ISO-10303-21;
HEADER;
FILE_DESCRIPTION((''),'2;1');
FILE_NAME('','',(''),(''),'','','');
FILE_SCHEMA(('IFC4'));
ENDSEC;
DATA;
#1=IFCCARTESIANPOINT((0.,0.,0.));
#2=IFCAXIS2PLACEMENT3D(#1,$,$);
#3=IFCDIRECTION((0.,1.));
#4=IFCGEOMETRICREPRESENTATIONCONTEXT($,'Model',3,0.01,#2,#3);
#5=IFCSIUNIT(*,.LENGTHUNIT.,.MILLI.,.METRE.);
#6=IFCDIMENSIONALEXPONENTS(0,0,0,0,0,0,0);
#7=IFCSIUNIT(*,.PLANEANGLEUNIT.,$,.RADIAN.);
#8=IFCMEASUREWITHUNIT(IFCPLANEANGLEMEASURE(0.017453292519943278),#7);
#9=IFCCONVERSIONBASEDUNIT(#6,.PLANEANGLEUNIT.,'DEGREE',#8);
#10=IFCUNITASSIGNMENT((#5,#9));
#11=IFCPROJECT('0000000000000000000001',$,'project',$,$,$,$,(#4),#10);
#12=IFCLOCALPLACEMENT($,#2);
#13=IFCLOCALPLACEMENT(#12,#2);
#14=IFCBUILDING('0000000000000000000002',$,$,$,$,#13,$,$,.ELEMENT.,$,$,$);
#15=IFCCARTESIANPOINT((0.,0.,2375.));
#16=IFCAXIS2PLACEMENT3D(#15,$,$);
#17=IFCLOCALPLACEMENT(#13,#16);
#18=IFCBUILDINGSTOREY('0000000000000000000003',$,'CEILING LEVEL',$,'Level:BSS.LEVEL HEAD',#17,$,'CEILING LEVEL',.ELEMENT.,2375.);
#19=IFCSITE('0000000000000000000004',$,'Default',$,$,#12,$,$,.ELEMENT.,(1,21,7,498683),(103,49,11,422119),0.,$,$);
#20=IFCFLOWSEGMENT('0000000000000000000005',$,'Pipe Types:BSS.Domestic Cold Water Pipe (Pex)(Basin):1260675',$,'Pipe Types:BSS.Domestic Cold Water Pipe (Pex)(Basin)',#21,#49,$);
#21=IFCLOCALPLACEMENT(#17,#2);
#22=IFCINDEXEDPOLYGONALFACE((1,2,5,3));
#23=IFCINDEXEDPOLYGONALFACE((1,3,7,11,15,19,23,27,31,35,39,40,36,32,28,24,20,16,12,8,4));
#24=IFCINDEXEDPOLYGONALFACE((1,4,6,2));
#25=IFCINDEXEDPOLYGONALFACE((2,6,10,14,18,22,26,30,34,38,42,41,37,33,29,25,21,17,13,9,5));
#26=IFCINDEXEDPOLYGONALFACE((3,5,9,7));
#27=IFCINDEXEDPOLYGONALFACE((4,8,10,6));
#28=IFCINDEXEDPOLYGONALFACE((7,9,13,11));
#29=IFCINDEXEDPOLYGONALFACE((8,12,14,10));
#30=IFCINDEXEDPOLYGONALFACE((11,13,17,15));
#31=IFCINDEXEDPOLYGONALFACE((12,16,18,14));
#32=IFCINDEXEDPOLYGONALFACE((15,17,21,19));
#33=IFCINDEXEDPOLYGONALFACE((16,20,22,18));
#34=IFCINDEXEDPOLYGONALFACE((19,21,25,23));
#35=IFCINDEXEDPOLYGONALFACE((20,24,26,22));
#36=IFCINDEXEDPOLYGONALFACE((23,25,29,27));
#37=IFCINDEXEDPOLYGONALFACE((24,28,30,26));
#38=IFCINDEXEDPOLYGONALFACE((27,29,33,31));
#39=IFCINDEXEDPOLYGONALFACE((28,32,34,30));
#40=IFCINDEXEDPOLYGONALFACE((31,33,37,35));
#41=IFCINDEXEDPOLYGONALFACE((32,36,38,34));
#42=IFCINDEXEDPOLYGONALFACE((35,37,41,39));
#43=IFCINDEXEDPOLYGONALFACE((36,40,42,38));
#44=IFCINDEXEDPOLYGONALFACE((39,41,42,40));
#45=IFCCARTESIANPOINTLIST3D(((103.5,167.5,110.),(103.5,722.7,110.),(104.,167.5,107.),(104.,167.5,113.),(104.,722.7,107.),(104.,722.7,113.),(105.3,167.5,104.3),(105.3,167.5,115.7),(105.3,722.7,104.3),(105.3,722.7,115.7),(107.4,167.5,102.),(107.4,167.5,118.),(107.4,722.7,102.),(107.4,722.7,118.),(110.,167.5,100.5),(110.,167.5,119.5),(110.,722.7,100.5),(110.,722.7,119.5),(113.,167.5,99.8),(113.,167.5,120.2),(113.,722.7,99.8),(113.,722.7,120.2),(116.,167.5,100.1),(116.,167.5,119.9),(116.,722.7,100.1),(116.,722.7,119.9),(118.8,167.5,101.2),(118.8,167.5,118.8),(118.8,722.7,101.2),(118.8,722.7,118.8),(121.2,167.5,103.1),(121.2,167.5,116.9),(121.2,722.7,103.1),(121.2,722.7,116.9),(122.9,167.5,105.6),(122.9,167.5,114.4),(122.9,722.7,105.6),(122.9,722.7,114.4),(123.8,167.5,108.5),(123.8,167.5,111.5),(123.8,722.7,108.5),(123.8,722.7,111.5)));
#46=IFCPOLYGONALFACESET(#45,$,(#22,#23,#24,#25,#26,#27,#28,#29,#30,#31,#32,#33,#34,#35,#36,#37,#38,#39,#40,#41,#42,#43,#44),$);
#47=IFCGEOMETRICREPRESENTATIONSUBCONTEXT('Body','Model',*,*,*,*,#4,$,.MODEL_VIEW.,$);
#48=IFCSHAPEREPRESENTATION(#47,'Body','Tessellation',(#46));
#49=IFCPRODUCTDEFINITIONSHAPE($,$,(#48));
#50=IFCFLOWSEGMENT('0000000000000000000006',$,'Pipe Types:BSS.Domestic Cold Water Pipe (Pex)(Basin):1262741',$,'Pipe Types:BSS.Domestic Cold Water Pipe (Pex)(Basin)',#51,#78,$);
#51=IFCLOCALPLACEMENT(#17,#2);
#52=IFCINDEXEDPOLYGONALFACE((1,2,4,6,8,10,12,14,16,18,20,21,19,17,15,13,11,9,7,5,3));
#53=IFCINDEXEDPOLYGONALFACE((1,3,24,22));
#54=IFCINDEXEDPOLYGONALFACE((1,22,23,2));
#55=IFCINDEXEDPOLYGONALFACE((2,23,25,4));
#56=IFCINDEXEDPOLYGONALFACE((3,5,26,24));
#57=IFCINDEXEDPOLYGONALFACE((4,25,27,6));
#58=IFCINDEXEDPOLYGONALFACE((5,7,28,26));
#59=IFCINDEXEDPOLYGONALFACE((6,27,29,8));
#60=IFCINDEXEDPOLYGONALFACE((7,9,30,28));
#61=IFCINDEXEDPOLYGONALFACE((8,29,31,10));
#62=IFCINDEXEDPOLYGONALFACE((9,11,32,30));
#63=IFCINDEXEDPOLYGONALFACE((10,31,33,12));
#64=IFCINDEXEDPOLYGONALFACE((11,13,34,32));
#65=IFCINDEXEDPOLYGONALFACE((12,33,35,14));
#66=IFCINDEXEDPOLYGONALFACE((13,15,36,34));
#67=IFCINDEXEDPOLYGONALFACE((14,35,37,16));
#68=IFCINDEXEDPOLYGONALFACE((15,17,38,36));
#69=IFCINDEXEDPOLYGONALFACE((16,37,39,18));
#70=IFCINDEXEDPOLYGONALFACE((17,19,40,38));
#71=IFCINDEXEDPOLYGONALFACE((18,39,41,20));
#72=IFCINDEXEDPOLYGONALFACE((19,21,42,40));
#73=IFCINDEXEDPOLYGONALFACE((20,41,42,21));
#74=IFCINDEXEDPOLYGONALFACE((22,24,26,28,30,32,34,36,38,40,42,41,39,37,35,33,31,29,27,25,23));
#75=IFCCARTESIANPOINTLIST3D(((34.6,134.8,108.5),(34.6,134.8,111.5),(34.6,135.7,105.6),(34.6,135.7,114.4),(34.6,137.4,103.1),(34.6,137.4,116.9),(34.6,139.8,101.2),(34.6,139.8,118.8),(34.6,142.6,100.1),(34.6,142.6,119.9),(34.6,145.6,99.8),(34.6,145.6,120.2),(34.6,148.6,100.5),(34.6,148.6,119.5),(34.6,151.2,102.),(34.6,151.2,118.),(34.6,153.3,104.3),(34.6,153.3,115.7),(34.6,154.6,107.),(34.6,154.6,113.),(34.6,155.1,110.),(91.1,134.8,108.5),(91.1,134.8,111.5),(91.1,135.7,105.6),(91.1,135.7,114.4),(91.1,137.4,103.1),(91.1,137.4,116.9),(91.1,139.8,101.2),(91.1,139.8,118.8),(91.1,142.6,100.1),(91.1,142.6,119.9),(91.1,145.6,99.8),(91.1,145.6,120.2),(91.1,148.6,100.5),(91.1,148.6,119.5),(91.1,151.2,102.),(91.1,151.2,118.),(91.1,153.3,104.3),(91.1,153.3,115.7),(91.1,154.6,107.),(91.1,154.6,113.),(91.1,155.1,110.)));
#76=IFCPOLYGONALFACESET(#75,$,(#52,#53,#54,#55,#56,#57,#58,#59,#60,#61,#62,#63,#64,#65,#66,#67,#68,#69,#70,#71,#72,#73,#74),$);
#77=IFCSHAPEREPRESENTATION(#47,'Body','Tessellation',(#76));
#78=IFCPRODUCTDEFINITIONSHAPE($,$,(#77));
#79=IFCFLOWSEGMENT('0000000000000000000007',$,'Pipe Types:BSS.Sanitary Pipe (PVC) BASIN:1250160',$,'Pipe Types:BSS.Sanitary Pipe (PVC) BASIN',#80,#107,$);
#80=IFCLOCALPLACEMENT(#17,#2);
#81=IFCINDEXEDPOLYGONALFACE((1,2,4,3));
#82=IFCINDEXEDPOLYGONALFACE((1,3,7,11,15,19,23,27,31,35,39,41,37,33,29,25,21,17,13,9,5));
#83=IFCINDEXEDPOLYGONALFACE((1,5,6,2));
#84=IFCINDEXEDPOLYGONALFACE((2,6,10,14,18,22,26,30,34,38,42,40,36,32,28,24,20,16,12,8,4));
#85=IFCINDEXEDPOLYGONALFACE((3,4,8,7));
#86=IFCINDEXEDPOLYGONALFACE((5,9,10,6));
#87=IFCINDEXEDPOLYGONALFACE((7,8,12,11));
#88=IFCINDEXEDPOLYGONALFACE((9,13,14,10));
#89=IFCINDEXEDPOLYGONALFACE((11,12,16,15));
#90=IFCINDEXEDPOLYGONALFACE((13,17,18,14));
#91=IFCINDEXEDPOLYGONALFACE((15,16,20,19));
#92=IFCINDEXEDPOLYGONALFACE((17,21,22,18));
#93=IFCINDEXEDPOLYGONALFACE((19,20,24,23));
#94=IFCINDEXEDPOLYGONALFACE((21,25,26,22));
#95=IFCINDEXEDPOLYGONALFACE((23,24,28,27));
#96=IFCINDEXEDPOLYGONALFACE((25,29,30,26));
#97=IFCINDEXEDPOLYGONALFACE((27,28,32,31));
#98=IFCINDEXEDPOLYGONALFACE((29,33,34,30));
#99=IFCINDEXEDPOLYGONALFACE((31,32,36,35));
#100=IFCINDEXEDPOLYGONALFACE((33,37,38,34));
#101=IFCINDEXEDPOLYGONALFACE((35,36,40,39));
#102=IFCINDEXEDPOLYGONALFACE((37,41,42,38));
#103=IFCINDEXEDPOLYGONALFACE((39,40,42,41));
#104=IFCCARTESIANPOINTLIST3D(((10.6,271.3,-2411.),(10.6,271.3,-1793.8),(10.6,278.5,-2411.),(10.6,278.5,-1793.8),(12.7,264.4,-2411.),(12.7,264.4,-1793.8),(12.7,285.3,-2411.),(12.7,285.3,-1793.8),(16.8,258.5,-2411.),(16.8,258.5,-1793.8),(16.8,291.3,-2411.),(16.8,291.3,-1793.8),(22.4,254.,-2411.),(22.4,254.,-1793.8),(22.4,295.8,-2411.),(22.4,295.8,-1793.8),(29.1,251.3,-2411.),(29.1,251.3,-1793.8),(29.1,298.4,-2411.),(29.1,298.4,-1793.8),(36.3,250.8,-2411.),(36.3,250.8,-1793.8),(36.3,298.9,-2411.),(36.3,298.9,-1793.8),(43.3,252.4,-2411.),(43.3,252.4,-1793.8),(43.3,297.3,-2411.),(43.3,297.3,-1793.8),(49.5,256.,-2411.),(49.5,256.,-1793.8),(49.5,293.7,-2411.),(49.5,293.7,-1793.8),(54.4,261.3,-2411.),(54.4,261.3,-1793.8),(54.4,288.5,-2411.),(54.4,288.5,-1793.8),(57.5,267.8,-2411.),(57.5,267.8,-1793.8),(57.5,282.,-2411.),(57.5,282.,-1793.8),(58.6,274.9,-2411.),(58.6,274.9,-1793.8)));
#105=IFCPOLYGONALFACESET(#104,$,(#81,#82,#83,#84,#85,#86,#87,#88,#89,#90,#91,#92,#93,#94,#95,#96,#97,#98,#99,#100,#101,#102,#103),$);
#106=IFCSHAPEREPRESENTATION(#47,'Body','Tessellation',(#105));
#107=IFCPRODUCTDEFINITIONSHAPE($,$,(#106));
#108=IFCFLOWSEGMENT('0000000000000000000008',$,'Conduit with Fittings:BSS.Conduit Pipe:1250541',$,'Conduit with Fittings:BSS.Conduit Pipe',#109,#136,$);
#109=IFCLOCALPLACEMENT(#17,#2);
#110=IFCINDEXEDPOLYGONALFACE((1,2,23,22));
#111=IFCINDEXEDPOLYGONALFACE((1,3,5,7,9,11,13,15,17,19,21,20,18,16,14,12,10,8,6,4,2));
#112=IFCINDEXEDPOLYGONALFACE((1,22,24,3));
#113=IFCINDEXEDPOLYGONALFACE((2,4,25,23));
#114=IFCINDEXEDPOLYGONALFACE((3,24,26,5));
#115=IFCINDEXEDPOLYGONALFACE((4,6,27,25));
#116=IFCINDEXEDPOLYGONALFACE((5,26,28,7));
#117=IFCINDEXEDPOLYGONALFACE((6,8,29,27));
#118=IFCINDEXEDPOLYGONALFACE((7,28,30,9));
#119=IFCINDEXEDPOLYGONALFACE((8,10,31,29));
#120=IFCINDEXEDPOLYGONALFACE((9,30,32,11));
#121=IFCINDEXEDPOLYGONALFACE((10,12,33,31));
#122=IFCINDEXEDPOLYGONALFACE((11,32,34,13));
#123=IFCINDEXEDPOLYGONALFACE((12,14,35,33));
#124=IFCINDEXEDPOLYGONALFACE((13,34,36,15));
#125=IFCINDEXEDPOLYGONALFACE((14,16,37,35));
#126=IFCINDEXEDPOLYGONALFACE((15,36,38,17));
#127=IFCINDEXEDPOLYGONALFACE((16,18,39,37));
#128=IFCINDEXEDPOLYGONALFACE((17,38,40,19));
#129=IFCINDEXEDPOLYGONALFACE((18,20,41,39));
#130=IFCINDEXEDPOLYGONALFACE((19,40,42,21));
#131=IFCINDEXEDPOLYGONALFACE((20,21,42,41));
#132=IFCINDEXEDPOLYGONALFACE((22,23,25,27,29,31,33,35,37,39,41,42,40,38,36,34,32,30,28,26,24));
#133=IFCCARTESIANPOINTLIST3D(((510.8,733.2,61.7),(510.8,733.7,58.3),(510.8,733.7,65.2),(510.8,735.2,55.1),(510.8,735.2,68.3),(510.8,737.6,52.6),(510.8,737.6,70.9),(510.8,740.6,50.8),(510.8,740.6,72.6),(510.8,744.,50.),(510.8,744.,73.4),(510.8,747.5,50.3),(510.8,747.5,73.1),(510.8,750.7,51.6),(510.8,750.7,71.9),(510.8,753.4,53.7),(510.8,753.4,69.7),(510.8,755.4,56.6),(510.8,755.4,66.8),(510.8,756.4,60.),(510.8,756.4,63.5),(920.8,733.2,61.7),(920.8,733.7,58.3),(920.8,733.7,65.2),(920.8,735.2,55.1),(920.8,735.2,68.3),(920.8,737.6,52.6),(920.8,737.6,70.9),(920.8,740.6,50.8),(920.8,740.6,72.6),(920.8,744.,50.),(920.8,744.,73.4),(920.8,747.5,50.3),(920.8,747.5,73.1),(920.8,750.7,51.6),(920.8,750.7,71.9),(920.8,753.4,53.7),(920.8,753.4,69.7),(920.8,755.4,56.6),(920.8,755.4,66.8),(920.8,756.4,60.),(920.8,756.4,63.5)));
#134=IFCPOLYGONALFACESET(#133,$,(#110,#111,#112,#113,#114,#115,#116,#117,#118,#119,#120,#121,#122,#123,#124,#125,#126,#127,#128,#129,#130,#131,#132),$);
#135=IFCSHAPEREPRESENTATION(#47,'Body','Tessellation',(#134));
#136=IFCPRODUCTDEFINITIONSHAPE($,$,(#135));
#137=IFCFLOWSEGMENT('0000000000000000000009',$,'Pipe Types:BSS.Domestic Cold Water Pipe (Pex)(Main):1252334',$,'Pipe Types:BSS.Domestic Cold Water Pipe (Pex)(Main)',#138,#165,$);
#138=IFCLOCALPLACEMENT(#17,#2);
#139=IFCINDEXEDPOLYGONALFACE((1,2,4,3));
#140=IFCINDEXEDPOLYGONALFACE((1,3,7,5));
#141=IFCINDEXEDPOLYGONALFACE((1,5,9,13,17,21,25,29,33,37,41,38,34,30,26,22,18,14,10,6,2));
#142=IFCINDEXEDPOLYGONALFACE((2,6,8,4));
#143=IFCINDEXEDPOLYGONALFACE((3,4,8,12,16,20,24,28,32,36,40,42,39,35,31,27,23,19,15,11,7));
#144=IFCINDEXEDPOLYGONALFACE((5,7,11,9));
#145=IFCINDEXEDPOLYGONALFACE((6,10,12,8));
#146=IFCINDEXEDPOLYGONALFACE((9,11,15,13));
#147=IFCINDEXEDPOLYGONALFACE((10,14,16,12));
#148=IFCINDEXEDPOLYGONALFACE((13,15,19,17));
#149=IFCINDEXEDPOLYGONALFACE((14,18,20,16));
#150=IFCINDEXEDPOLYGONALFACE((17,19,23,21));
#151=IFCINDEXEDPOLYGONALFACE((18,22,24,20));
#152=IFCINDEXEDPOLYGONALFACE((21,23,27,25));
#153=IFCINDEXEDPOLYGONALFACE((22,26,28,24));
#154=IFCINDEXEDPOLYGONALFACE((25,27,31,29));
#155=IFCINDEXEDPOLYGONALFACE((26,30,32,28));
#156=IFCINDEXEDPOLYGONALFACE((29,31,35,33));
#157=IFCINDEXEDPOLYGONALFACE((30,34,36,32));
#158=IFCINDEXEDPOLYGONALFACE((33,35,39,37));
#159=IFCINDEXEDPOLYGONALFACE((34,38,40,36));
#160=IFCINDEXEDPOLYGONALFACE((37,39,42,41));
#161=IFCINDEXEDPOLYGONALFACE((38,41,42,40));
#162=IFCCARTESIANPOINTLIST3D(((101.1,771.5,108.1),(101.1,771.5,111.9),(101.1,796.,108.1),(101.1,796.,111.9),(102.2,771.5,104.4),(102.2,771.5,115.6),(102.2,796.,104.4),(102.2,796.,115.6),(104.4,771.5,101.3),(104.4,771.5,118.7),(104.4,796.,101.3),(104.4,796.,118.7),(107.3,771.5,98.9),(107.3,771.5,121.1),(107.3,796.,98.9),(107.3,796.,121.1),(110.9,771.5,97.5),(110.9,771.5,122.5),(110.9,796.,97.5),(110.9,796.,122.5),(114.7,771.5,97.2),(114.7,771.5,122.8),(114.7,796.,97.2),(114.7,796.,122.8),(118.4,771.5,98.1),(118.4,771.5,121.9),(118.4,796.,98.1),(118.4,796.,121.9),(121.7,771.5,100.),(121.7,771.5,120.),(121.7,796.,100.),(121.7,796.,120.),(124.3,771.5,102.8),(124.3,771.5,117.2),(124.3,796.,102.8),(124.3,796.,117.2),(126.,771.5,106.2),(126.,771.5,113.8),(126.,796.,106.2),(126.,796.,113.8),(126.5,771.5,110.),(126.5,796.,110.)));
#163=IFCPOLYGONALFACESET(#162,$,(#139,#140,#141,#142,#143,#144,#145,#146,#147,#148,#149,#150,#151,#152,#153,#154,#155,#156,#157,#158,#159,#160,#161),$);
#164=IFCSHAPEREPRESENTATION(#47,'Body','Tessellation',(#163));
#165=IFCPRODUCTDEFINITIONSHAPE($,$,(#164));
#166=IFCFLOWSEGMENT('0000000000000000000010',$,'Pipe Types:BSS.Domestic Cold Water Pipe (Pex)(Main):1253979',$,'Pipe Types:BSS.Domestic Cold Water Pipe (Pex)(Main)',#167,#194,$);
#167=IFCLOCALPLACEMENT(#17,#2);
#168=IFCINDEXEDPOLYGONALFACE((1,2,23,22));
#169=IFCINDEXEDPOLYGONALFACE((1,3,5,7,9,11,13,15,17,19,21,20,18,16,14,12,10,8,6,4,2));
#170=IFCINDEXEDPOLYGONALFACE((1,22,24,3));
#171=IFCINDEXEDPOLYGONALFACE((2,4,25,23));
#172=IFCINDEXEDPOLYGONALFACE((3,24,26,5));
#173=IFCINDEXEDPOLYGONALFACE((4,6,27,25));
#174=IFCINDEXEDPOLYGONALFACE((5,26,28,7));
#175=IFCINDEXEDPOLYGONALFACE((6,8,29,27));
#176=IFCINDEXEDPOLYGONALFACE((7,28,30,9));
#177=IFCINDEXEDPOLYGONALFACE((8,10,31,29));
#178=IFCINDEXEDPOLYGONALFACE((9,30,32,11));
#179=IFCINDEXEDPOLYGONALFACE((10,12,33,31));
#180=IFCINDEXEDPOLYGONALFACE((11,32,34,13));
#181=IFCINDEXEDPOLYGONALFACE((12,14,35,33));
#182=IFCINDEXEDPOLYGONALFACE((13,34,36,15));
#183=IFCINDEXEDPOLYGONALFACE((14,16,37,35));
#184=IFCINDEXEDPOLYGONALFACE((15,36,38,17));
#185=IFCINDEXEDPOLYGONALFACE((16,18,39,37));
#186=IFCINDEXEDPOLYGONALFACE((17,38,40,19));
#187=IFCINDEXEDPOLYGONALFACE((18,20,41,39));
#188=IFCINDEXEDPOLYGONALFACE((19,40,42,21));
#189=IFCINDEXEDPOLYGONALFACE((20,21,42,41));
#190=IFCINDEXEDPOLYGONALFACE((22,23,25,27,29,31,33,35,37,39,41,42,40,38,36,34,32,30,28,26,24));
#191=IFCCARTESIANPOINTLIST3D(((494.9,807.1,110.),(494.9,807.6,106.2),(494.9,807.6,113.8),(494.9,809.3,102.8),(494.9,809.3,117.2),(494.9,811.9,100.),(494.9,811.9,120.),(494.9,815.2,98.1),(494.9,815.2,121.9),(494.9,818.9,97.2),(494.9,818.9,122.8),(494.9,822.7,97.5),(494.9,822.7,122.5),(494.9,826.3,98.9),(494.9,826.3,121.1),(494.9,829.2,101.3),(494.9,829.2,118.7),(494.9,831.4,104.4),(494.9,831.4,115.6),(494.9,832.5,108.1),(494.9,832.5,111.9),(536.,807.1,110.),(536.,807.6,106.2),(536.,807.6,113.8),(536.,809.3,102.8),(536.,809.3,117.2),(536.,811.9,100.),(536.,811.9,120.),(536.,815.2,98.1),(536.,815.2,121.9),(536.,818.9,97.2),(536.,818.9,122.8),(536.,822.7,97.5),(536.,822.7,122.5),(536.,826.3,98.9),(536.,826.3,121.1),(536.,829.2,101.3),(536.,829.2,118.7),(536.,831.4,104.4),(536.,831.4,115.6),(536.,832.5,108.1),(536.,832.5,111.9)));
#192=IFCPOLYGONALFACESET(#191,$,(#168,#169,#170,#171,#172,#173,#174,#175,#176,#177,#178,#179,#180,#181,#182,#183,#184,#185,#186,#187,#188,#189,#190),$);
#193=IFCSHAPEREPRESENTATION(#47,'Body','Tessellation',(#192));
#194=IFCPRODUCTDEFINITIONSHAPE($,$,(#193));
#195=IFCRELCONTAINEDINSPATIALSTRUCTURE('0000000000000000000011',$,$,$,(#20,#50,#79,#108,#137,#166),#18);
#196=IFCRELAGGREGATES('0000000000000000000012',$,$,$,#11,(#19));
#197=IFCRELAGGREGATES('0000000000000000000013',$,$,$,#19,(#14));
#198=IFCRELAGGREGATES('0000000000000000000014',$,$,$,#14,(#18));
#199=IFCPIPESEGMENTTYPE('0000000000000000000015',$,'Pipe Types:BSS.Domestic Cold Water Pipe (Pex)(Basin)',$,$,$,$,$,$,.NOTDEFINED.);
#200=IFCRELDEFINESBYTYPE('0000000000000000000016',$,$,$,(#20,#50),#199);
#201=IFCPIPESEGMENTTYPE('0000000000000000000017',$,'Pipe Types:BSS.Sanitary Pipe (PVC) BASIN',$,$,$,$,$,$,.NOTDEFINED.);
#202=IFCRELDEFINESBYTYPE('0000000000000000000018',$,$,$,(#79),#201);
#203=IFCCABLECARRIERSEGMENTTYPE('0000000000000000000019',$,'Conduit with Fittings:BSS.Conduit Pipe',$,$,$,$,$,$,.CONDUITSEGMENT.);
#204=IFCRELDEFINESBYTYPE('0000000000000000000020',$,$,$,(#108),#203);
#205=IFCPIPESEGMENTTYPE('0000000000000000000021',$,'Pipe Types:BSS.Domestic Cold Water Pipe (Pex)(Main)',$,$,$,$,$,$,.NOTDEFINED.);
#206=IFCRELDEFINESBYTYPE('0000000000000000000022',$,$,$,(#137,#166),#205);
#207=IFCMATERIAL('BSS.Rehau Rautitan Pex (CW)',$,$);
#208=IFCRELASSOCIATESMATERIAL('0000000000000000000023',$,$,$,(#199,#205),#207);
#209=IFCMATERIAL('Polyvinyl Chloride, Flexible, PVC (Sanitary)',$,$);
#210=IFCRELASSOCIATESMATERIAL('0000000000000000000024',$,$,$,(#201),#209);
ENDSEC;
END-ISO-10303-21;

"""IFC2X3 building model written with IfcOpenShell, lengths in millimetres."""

from ifc_helpers import new_model, entity, si_unit, converted_unit, direction, frame, frame_2d, origin, origin_2d_with_axis, place, context, subcontext, project, spatial, circle, extrude, material, type_object, element, save


model = new_model("IFC2X3")

# Units and contexts
model_context = context("Model", 3, precision=0.01, world=origin(), true_north=direction((0.0, 1.0)))
body_context = subcontext(model_context, "Body", "Model", "MODEL_VIEW")
ifc_project = project(units=[si_unit("LENGTHUNIT", "METRE", prefix="MILLI"), converted_unit("PLANEANGLEUNIT", "DEGREE", entity("IfcPlaneAngleMeasure", 0.017453292519943278), si_unit("PLANEANGLEUNIT", "RADIAN"), dimensions=[0, 0, 0, 0, 0, 0, 0])], contexts=[model_context])

# Site, building, storey
site_placement = place(None, origin())
site = spatial("IfcSite", under=ifc_project, at=site_placement, Name="Default", CompositionType="ELEMENT", RefLatitude=(1, 21, 7, 498683), RefLongitude=(103, 49, 11, 422119), RefElevation=0.0)
building_placement = place(site_placement, origin())
building = spatial("IfcBuilding", under=site, at=building_placement, CompositionType="ELEMENT")
storey_placement = place(building_placement, frame((0.0, 0.0, 2375.0)))
storey = spatial("IfcBuildingStorey", under=building, at=storey_placement, Name="CEILING LEVEL", ObjectType="Level:BSS.LEVEL HEAD", LongName="CEILING LEVEL", CompositionType="ELEMENT", Elevation=2375.0)

# Flow segments
ifc_material_1 = material(Name="BSS.Rehau Rautitan Pex (CW)")
pipe_segment_type_1 = type_object("IfcPipeSegmentType", Name="Pipe Types:BSS.Domestic Cold Water Pipe (Pex)(Basin)", PredefinedType="NOTDEFINED", material=ifc_material_1)
flow_segment_1_placement = place(storey_placement, origin())
element("IfcFlowSegment", 1, at=flow_segment_1_placement, inside=storey, type_object=pipe_segment_type_1, Name="Pipe Types:BSS.Domestic Cold Water Pipe (Pex)(Basin):1260675", ObjectType="Pipe Types:BSS.Domestic Cold Water Pipe (Pex)(Basin)", context=body_context, shape_type="SweptSolid", body=[
    extrude(circle(Radius=10.2, at=frame_2d((0.0, 0.0), x_axis=(1.0, 0.0))), frame((113.7, 167.5, 110.0), z_axis=(0.0, 1.0, 0.0), x_axis=(-1.0, 0.0, 0.0)), (0.0, 0.0, 1.0), 555.2),
])
flow_segment_2_placement = place(storey_placement, origin())
element("IfcFlowSegment", 2, at=flow_segment_2_placement, inside=storey, type_object=pipe_segment_type_1, Name="Pipe Types:BSS.Domestic Cold Water Pipe (Pex)(Basin):1262741", ObjectType="Pipe Types:BSS.Domestic Cold Water Pipe (Pex)(Basin)", context=body_context, shape_type="SweptSolid", body=[
    extrude(circle(Radius=10.2, at=frame_2d((0.0, 0.0), x_axis=(1.0, 0.0))), frame((34.6, 144.9, 110.0), z_axis=(1.0, 0.0, 0.0), x_axis=(0.0, 1.0, 0.0)), (0.0, 0.0, 1.0), 56.5),
])
ifc_material_2 = material(Name="Polyvinyl Chloride, Flexible, PVC (Sanitary)")
pipe_segment_type_2 = type_object("IfcPipeSegmentType", Name="Pipe Types:BSS.Sanitary Pipe (PVC) BASIN", PredefinedType="NOTDEFINED", material=ifc_material_2)
flow_segment_3_placement = place(storey_placement, origin())
element("IfcFlowSegment", 3, at=flow_segment_3_placement, inside=storey, type_object=pipe_segment_type_2, Name="Pipe Types:BSS.Sanitary Pipe (PVC) BASIN:1250160", ObjectType="Pipe Types:BSS.Sanitary Pipe (PVC) BASIN", context=body_context, shape_type="SweptSolid", body=[
    extrude(circle(Radius=24.1, at=frame_2d((0.0, 0.0), x_axis=(1.0, 0.0))), frame((34.5, 274.9, -2411.0)), (0.0, 0.0, 1.0), 617.2),
])
cable_carrier_segment_type = type_object("IfcCableCarrierSegmentType", Name="Conduit with Fittings:BSS.Conduit Pipe", PredefinedType="CONDUITSEGMENT")
flow_segment_4_placement = place(storey_placement, origin())
element("IfcFlowSegment", 4, at=flow_segment_4_placement, inside=storey, type_object=cable_carrier_segment_type, Name="Conduit with Fittings:BSS.Conduit Pipe:1250541", ObjectType="Conduit with Fittings:BSS.Conduit Pipe", context=body_context, shape_type="SweptSolid", body=[
    extrude(circle(Radius=11.7, at=frame_2d((0.0, 0.0), x_axis=(1.0, 0.0))), frame((510.8, 744.9, 61.7), z_axis=(1.0, 0.0, 0.0), x_axis=(0.0, -1.0, 0.0)), (0.0, 0.0, 1.0), 410.0),
])
pipe_segment_type_3 = type_object("IfcPipeSegmentType", Name="Pipe Types:BSS.Domestic Cold Water Pipe (Pex)(Main)", PredefinedType="NOTDEFINED", material=ifc_material_1)
flow_segment_5_placement = place(storey_placement, origin())
element("IfcFlowSegment", 5, at=flow_segment_5_placement, inside=storey, type_object=pipe_segment_type_3, Name="Pipe Types:BSS.Domestic Cold Water Pipe (Pex)(Main):1252334", ObjectType="Pipe Types:BSS.Domestic Cold Water Pipe (Pex)(Main)", context=body_context, shape_type="SweptSolid", body=[
    extrude(circle(Radius=12.8, at=frame_2d((0.0, 0.0), x_axis=(1.0, 0.0))), frame((113.7, 771.5, 110.0), z_axis=(0.0, 1.0, 0.0), x_axis=(1.0, 0.0, 0.0)), (0.0, 0.0, 1.0), 24.5),
])
flow_segment_6_placement = place(storey_placement, origin())
element("IfcFlowSegment", 6, at=flow_segment_6_placement, inside=storey, type_object=pipe_segment_type_3, Name="Pipe Types:BSS.Domestic Cold Water Pipe (Pex)(Main):1253979", ObjectType="Pipe Types:BSS.Domestic Cold Water Pipe (Pex)(Main)", context=body_context, shape_type="SweptSolid", body=[
    extrude(circle(Radius=12.8, at=origin_2d_with_axis()), frame((494.9, 819.9, 110.0), z_axis=(1.0, 0.0, 0.0), x_axis=(0.0, -1.0, 0.0)), (0.0, 0.0, 1.0), 41.1),
])

save(model, "model.ifc")
